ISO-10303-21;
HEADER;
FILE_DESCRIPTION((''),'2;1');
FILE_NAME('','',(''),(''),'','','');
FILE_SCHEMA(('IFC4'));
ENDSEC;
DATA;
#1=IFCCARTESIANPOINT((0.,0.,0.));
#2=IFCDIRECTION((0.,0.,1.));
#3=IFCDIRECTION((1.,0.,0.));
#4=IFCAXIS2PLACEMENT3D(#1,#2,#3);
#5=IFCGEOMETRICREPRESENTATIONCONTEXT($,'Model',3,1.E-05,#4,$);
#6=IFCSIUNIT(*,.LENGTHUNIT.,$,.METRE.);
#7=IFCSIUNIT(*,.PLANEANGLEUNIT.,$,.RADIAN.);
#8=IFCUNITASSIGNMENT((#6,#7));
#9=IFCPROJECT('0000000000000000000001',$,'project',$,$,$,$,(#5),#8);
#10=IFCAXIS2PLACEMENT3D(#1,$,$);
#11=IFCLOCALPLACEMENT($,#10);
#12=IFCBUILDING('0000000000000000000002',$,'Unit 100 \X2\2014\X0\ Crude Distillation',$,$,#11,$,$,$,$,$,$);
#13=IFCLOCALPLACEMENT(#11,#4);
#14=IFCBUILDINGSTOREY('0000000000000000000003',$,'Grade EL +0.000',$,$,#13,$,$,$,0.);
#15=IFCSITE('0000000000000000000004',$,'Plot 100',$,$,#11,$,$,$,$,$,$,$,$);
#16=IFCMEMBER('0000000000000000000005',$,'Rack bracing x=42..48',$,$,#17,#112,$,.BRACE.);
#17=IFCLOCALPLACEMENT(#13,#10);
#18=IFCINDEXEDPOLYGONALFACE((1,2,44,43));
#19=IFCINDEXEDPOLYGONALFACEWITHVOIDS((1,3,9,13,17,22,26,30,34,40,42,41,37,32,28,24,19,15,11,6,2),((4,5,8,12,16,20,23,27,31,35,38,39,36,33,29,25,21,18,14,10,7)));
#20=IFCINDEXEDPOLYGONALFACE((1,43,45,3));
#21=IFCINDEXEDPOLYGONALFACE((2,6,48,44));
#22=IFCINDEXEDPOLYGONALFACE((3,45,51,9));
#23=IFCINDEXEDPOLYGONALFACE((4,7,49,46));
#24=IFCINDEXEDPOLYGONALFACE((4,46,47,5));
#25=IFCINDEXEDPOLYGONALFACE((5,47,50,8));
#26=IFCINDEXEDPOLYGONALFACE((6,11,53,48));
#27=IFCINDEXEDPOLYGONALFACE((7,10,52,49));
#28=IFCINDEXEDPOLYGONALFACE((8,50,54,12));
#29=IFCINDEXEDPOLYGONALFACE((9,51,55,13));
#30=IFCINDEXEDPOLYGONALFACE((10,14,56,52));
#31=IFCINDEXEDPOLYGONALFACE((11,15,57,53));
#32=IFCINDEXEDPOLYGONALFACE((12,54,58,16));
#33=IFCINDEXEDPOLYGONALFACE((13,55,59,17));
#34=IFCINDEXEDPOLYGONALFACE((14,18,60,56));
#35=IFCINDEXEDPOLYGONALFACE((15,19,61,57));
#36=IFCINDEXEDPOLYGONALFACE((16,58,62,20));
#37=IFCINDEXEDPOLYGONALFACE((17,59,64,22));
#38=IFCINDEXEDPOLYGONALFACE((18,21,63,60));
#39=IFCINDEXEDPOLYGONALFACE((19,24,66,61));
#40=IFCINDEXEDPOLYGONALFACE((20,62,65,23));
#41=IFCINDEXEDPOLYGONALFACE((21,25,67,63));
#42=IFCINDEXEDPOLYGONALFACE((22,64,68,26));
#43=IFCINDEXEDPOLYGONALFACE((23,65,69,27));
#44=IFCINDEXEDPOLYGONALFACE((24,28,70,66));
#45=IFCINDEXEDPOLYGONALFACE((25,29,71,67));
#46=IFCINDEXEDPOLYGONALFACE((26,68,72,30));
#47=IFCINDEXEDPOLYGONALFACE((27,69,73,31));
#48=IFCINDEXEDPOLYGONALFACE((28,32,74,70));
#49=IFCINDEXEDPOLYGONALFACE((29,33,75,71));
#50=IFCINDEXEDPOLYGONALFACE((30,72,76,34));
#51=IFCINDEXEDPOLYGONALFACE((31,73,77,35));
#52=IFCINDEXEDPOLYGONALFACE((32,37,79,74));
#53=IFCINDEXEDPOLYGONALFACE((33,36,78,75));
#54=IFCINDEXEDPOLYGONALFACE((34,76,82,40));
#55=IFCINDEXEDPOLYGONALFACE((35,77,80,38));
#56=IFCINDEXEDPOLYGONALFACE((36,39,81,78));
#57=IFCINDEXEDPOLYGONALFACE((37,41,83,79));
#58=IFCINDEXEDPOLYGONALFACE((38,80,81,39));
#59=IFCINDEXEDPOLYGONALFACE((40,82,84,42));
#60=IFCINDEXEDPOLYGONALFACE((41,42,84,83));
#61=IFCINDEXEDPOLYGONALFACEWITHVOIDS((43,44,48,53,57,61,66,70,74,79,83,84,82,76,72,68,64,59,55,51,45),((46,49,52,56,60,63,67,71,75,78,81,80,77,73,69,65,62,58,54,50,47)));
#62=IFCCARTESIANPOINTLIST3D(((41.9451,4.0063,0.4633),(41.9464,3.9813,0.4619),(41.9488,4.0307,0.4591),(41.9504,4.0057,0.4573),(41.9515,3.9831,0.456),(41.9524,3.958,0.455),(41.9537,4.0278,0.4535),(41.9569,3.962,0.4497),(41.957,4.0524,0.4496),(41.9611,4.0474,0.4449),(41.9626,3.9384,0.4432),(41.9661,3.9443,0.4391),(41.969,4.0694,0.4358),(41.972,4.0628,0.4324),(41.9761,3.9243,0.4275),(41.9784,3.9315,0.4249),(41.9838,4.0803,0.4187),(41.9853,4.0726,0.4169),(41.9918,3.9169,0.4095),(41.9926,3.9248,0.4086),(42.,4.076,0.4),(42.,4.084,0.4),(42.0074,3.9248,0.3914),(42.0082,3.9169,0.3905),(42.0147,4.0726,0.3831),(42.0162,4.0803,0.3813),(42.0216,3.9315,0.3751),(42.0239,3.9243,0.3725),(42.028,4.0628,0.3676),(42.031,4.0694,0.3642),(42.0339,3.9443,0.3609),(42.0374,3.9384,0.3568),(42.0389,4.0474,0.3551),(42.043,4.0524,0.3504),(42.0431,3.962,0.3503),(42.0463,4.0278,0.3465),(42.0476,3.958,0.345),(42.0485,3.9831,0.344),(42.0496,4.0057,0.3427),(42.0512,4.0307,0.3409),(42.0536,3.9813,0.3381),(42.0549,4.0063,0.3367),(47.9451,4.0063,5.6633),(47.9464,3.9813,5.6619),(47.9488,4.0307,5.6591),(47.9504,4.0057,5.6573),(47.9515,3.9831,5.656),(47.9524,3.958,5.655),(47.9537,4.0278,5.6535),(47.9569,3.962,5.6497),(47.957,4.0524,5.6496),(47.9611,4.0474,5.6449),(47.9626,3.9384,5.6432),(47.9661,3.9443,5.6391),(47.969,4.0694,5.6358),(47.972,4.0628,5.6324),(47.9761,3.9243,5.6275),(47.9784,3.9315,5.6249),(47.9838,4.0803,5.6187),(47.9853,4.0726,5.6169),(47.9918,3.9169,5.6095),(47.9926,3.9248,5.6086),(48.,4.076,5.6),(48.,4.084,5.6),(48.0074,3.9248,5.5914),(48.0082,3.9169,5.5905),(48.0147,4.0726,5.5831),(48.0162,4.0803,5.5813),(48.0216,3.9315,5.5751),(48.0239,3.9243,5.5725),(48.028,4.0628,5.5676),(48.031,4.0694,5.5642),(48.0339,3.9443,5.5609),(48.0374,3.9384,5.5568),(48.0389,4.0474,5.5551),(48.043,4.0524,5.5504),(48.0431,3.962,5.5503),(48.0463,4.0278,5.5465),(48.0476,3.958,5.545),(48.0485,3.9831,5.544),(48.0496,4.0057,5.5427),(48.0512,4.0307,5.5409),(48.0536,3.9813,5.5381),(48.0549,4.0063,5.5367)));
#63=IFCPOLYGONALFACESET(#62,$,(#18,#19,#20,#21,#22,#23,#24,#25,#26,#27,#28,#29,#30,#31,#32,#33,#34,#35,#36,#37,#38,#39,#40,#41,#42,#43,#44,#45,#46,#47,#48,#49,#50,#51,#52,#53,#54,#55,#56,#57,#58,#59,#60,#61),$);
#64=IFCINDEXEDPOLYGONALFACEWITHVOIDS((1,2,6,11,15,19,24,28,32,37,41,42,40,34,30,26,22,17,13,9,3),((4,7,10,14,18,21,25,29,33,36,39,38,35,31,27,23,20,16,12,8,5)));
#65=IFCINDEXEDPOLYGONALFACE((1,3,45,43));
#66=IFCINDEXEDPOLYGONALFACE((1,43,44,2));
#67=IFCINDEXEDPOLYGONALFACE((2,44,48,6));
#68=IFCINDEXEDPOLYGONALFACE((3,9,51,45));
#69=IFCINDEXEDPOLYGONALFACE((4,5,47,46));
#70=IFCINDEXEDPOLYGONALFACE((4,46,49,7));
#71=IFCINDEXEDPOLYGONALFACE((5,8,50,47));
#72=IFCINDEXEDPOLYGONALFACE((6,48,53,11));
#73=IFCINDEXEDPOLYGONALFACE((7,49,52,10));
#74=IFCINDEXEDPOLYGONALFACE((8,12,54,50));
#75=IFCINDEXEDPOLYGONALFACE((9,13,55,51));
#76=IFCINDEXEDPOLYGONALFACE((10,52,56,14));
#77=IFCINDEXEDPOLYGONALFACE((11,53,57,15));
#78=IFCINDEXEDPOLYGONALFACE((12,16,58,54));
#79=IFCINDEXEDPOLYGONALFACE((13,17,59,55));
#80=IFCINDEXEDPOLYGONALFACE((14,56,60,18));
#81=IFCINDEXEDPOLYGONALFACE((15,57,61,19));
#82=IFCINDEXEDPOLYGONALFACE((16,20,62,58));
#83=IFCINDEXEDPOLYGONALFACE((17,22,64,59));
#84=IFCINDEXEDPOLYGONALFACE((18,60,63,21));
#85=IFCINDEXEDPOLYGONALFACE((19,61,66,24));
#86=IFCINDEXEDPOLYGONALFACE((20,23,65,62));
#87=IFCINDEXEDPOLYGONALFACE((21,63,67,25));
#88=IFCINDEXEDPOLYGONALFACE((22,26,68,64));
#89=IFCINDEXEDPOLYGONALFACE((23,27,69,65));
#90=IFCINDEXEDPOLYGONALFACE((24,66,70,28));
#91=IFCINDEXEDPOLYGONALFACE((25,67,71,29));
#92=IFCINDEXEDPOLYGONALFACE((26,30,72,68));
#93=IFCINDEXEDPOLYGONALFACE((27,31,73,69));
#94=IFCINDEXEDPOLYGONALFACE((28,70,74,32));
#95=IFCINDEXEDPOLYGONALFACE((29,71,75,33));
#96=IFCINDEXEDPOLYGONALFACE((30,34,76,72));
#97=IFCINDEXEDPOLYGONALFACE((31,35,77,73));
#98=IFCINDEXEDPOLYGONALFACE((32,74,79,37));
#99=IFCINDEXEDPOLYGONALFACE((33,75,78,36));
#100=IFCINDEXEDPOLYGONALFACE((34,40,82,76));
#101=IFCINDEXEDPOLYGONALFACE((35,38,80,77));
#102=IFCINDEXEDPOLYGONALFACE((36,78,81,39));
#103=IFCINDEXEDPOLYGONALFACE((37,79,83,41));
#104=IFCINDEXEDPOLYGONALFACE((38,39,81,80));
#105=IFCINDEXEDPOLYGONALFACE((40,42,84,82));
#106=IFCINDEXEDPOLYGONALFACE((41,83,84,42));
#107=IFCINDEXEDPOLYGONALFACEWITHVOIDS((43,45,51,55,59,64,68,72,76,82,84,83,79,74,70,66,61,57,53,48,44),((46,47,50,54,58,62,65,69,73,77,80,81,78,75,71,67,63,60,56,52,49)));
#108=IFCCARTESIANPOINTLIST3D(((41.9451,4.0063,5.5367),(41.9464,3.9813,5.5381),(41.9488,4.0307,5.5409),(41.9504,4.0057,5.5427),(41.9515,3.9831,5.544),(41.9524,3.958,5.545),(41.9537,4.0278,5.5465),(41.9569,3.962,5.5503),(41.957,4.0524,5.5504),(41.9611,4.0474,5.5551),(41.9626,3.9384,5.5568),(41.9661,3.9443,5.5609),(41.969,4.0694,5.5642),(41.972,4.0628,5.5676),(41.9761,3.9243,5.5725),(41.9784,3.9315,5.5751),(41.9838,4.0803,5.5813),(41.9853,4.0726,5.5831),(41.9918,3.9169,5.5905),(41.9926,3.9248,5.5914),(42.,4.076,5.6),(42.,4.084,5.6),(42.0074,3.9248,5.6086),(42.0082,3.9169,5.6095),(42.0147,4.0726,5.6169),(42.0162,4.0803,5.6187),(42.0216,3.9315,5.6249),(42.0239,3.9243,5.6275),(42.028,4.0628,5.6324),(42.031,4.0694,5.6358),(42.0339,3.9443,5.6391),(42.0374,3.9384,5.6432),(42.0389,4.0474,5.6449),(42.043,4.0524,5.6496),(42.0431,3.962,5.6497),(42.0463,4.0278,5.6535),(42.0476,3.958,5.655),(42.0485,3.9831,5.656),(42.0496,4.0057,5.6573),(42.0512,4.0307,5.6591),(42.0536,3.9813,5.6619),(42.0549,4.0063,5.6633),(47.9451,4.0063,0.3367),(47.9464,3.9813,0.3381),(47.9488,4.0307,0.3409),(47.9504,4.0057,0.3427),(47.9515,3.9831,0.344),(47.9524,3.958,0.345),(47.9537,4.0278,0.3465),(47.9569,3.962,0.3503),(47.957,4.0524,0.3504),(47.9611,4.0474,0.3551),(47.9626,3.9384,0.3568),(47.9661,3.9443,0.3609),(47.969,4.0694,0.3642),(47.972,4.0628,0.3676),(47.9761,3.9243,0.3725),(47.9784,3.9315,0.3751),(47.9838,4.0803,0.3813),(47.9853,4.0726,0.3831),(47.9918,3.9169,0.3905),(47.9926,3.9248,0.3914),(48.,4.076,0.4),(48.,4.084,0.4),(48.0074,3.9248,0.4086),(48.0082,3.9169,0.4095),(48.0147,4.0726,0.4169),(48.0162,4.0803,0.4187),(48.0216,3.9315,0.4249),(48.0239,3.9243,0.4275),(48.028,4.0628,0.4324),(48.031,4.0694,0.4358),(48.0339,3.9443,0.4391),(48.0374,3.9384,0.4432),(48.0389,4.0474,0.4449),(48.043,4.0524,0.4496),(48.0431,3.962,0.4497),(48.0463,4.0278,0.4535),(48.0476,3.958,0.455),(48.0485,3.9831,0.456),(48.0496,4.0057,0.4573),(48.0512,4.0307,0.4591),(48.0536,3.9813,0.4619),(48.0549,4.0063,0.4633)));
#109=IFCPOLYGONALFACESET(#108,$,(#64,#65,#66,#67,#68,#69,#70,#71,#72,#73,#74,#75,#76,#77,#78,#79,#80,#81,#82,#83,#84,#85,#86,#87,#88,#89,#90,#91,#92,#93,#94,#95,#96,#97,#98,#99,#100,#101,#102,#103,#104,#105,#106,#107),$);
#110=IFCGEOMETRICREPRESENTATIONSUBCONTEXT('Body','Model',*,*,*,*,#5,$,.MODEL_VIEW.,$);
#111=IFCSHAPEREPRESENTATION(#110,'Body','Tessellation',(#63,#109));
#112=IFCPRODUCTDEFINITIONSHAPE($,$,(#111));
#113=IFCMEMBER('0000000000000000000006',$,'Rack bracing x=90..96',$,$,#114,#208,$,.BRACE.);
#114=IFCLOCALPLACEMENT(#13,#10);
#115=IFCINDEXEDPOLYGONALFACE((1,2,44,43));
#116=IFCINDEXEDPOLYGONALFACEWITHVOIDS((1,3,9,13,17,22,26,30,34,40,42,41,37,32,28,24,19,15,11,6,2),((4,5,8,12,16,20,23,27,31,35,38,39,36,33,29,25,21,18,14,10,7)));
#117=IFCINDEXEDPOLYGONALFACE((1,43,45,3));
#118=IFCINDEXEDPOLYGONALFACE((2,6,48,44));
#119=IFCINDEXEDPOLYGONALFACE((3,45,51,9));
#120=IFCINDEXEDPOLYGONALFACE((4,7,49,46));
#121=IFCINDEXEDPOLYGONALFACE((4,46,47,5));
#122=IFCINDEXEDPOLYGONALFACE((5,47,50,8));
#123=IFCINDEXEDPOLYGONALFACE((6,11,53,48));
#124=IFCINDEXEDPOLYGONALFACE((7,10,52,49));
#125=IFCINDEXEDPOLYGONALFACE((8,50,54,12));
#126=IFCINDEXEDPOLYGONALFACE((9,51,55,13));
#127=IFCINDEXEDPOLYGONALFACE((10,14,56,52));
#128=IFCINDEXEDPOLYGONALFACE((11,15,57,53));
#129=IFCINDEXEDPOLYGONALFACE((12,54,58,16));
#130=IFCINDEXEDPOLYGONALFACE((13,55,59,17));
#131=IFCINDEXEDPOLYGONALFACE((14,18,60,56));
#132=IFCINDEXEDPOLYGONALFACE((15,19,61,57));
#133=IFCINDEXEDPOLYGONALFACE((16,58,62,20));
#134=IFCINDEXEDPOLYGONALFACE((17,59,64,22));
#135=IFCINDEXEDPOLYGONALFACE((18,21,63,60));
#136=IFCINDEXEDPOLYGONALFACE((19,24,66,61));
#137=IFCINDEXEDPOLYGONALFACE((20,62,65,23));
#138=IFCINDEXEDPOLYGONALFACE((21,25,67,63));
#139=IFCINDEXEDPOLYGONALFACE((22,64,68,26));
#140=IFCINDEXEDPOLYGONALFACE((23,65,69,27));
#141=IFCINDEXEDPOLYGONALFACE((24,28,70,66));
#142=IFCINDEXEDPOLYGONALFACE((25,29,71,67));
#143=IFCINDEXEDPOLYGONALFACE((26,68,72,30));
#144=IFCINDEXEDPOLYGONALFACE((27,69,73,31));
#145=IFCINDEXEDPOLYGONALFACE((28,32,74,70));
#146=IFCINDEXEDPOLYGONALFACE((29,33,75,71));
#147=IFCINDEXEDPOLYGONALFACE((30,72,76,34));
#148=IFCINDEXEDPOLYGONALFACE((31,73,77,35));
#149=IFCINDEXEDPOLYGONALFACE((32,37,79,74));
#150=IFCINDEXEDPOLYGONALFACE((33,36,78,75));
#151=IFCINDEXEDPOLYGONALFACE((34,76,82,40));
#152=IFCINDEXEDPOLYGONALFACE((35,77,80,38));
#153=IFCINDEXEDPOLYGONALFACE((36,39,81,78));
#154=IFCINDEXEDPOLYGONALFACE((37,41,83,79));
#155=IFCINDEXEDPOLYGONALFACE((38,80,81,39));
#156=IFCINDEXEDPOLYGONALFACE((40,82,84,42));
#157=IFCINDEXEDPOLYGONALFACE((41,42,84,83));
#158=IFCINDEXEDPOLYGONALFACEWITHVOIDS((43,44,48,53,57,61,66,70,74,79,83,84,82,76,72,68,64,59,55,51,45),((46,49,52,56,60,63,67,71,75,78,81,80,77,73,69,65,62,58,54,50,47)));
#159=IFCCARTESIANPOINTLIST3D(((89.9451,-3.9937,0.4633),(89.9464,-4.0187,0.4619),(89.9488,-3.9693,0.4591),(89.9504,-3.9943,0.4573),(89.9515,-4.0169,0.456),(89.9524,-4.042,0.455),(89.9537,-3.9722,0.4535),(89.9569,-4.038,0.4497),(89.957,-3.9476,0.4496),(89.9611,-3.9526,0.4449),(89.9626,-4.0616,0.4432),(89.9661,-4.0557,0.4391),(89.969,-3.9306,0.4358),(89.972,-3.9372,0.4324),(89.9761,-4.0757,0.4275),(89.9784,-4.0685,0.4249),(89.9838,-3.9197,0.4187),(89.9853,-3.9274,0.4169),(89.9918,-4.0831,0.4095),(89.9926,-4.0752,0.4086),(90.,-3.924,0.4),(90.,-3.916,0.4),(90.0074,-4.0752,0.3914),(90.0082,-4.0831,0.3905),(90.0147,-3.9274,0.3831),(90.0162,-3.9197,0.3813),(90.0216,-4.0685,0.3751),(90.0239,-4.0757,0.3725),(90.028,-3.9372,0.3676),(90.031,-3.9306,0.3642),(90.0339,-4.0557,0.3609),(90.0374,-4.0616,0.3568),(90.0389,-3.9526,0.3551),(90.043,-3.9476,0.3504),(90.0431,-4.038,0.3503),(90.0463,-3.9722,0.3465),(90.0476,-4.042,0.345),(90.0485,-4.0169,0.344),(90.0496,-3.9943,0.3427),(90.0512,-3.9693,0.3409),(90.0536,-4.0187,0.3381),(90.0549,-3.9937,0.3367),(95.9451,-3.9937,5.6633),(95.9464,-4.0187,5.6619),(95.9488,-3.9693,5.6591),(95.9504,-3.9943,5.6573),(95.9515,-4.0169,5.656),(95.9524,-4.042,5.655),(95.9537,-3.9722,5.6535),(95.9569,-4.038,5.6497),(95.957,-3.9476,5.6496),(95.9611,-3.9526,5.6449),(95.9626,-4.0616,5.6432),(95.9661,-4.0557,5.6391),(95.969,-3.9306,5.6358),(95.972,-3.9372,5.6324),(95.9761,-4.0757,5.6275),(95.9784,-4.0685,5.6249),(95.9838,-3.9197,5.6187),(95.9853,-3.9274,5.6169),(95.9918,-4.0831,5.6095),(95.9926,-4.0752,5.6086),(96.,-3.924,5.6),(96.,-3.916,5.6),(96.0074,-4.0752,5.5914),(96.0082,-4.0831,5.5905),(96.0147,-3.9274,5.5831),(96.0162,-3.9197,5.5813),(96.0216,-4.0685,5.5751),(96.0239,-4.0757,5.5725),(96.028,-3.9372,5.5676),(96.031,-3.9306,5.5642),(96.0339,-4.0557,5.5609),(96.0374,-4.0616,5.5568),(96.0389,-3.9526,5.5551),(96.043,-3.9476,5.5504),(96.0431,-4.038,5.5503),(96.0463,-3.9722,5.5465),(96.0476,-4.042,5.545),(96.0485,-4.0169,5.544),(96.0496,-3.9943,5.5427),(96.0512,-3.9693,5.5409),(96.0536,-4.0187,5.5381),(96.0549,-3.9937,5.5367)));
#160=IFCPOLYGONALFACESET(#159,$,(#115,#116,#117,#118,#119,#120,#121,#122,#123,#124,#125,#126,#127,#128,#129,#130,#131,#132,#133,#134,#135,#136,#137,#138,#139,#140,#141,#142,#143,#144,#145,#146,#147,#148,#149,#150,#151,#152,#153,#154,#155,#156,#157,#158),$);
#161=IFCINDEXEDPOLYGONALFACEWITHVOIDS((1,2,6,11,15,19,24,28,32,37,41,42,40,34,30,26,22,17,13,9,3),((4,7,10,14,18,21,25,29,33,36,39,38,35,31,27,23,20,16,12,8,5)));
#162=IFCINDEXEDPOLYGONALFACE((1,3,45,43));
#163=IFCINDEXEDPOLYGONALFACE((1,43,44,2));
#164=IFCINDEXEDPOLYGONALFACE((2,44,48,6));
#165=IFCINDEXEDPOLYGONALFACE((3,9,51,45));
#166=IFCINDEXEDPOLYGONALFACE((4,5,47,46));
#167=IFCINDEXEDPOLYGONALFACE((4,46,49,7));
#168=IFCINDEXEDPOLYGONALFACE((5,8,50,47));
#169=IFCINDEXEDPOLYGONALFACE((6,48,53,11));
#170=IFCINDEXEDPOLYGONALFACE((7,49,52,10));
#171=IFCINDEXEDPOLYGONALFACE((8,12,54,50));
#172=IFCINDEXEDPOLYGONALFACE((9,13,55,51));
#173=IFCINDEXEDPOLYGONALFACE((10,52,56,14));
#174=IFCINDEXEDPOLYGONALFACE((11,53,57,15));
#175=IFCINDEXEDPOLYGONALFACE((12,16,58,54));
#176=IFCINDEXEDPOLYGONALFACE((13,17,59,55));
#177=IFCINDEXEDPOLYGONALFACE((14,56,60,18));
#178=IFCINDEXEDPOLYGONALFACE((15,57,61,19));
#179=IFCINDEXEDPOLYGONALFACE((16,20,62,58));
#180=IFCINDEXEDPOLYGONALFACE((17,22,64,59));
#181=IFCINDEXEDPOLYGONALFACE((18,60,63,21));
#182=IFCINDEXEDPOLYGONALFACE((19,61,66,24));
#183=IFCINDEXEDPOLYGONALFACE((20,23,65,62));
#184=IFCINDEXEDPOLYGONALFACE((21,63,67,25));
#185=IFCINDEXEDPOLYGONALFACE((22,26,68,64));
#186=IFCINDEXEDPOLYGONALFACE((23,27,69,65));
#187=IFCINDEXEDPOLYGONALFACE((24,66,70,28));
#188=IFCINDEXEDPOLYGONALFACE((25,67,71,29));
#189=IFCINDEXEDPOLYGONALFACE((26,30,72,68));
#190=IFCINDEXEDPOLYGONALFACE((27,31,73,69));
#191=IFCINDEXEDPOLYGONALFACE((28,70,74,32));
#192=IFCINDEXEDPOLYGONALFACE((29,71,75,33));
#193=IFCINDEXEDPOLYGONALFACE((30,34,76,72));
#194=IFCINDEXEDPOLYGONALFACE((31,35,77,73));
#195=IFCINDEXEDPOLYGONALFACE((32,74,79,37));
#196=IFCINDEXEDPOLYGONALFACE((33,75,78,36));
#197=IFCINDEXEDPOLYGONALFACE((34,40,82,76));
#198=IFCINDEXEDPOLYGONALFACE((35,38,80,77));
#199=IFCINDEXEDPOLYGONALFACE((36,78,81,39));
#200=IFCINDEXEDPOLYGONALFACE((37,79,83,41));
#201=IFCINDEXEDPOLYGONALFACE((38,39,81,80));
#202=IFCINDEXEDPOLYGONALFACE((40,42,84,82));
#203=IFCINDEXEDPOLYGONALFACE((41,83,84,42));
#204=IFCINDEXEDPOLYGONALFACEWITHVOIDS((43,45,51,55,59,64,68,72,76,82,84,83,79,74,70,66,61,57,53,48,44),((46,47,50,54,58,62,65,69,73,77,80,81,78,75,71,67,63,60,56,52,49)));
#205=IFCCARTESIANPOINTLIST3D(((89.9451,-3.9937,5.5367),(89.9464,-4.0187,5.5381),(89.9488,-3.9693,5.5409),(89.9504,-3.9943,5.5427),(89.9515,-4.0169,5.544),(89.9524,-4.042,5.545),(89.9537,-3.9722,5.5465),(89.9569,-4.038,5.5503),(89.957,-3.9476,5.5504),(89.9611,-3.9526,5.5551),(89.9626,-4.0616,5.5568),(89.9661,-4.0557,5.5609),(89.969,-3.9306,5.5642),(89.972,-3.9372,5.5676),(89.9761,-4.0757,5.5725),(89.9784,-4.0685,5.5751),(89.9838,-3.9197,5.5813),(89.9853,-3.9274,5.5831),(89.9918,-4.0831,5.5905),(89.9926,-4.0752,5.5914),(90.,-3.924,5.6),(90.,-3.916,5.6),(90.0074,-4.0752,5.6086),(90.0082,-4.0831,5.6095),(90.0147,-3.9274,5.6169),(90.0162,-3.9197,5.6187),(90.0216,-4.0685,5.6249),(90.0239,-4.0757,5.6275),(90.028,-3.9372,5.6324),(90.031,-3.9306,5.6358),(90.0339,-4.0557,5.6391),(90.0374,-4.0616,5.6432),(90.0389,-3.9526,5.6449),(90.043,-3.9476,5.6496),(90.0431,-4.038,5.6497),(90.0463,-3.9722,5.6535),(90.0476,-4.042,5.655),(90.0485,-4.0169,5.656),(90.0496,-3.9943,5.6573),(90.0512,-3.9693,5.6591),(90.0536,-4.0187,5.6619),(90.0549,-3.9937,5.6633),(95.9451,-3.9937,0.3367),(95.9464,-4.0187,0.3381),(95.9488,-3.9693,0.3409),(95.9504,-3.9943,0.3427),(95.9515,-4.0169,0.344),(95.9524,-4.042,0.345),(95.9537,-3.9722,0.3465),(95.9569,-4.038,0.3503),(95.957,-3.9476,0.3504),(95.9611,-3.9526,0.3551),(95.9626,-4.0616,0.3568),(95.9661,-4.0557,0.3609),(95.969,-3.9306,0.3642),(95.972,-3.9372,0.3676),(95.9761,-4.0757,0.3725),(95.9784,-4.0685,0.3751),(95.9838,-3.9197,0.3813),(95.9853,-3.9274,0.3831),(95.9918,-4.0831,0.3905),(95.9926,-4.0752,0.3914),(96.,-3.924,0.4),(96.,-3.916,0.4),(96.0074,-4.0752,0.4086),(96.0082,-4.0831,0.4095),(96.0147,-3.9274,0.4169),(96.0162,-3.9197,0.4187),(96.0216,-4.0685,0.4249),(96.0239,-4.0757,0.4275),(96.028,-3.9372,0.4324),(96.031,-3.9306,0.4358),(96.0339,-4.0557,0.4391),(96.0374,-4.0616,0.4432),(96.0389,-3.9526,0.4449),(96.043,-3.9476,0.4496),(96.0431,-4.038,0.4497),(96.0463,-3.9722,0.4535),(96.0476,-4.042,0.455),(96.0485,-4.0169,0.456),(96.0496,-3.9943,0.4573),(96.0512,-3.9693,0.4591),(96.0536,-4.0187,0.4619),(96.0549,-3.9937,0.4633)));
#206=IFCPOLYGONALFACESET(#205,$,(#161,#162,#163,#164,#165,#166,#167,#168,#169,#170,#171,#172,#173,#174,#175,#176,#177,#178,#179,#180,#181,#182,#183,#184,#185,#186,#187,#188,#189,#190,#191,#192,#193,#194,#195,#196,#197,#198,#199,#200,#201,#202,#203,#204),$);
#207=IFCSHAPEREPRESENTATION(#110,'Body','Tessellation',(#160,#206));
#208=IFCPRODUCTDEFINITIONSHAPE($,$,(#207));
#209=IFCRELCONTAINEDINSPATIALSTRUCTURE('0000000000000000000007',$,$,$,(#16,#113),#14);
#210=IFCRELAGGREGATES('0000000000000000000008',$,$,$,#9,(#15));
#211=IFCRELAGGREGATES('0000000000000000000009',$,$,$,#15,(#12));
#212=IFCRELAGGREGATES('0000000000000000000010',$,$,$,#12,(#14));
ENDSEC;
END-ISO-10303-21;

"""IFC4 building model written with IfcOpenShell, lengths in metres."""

from ifc_helpers import new_model, si_unit, frame, origin, origin_with_axes, origin_2d, place, context, subcontext, project, spatial, hollow_circle, extrude, element, save


model = new_model("IFC4")

# Units and contexts
model_context = context("Model", 3, precision=1e-05, world=origin_with_axes())
body_context = subcontext(model_context, "Body", "Model", "MODEL_VIEW")
ifc_project = project(units=[si_unit("LENGTHUNIT", "METRE"), si_unit("PLANEANGLEUNIT", "RADIAN")], contexts=[model_context])

# Site, building, storey
placement = place(None, origin())
site = spatial("IfcSite", under=ifc_project, at=placement, Name="Plot 100")
building = spatial("IfcBuilding", under=site, at=placement, Name="Unit 100 — Crude Distillation")
storey_placement = place(placement, origin_with_axes())
storey = spatial("IfcBuildingStorey", under=building, at=storey_placement, Name="Grade EL +0.000", Elevation=0.0)

# Members
member_1_placement = place(storey_placement, origin_with_axes())
element("IfcMember", 1, at=member_1_placement, inside=storey, Name="Rack bracing x=42..48", PredefinedType="BRACE", context=body_context, shape_type="SweptSolid", body=[
    extrude(hollow_circle(Radius=0.084, WallThickness=0.008, at=origin_2d()), frame((42.0, 4.0, 0.4), z_axis=(0.755689, 0.0, 0.654931), x_axis=(0.0, 1.0, 0.0)), (0.0, 0.0, 1.0), 7.9398),
    extrude(hollow_circle(Radius=0.084, WallThickness=0.008, at=origin_2d()), frame((42.0, 4.0, 5.6), z_axis=(0.755689, 0.0, -0.654931), x_axis=(0.0, 1.0, 0.0)), (0.0, 0.0, 1.0), 7.9398),
])
member_2_placement = place(storey_placement, origin_with_axes())
element("IfcMember", 2, at=member_2_placement, inside=storey, Name="Rack bracing x=90..96", PredefinedType="BRACE", context=body_context, shape_type="SweptSolid", body=[
    extrude(hollow_circle(Radius=0.084, WallThickness=0.008, at=origin_2d()), frame((90.0, -4.0, 0.4), z_axis=(0.755689, 0.0, 0.654931), x_axis=(0.0, 1.0, 0.0)), (0.0, 0.0, 1.0), 7.9398),
    extrude(hollow_circle(Radius=0.084, WallThickness=0.008, at=origin_2d()), frame((90.0, -4.0, 5.6), z_axis=(0.755689, 0.0, -0.654931), x_axis=(0.0, 1.0, 0.0)), (0.0, 0.0, 1.0), 7.9398),
])

save(model, "model.ifc")
